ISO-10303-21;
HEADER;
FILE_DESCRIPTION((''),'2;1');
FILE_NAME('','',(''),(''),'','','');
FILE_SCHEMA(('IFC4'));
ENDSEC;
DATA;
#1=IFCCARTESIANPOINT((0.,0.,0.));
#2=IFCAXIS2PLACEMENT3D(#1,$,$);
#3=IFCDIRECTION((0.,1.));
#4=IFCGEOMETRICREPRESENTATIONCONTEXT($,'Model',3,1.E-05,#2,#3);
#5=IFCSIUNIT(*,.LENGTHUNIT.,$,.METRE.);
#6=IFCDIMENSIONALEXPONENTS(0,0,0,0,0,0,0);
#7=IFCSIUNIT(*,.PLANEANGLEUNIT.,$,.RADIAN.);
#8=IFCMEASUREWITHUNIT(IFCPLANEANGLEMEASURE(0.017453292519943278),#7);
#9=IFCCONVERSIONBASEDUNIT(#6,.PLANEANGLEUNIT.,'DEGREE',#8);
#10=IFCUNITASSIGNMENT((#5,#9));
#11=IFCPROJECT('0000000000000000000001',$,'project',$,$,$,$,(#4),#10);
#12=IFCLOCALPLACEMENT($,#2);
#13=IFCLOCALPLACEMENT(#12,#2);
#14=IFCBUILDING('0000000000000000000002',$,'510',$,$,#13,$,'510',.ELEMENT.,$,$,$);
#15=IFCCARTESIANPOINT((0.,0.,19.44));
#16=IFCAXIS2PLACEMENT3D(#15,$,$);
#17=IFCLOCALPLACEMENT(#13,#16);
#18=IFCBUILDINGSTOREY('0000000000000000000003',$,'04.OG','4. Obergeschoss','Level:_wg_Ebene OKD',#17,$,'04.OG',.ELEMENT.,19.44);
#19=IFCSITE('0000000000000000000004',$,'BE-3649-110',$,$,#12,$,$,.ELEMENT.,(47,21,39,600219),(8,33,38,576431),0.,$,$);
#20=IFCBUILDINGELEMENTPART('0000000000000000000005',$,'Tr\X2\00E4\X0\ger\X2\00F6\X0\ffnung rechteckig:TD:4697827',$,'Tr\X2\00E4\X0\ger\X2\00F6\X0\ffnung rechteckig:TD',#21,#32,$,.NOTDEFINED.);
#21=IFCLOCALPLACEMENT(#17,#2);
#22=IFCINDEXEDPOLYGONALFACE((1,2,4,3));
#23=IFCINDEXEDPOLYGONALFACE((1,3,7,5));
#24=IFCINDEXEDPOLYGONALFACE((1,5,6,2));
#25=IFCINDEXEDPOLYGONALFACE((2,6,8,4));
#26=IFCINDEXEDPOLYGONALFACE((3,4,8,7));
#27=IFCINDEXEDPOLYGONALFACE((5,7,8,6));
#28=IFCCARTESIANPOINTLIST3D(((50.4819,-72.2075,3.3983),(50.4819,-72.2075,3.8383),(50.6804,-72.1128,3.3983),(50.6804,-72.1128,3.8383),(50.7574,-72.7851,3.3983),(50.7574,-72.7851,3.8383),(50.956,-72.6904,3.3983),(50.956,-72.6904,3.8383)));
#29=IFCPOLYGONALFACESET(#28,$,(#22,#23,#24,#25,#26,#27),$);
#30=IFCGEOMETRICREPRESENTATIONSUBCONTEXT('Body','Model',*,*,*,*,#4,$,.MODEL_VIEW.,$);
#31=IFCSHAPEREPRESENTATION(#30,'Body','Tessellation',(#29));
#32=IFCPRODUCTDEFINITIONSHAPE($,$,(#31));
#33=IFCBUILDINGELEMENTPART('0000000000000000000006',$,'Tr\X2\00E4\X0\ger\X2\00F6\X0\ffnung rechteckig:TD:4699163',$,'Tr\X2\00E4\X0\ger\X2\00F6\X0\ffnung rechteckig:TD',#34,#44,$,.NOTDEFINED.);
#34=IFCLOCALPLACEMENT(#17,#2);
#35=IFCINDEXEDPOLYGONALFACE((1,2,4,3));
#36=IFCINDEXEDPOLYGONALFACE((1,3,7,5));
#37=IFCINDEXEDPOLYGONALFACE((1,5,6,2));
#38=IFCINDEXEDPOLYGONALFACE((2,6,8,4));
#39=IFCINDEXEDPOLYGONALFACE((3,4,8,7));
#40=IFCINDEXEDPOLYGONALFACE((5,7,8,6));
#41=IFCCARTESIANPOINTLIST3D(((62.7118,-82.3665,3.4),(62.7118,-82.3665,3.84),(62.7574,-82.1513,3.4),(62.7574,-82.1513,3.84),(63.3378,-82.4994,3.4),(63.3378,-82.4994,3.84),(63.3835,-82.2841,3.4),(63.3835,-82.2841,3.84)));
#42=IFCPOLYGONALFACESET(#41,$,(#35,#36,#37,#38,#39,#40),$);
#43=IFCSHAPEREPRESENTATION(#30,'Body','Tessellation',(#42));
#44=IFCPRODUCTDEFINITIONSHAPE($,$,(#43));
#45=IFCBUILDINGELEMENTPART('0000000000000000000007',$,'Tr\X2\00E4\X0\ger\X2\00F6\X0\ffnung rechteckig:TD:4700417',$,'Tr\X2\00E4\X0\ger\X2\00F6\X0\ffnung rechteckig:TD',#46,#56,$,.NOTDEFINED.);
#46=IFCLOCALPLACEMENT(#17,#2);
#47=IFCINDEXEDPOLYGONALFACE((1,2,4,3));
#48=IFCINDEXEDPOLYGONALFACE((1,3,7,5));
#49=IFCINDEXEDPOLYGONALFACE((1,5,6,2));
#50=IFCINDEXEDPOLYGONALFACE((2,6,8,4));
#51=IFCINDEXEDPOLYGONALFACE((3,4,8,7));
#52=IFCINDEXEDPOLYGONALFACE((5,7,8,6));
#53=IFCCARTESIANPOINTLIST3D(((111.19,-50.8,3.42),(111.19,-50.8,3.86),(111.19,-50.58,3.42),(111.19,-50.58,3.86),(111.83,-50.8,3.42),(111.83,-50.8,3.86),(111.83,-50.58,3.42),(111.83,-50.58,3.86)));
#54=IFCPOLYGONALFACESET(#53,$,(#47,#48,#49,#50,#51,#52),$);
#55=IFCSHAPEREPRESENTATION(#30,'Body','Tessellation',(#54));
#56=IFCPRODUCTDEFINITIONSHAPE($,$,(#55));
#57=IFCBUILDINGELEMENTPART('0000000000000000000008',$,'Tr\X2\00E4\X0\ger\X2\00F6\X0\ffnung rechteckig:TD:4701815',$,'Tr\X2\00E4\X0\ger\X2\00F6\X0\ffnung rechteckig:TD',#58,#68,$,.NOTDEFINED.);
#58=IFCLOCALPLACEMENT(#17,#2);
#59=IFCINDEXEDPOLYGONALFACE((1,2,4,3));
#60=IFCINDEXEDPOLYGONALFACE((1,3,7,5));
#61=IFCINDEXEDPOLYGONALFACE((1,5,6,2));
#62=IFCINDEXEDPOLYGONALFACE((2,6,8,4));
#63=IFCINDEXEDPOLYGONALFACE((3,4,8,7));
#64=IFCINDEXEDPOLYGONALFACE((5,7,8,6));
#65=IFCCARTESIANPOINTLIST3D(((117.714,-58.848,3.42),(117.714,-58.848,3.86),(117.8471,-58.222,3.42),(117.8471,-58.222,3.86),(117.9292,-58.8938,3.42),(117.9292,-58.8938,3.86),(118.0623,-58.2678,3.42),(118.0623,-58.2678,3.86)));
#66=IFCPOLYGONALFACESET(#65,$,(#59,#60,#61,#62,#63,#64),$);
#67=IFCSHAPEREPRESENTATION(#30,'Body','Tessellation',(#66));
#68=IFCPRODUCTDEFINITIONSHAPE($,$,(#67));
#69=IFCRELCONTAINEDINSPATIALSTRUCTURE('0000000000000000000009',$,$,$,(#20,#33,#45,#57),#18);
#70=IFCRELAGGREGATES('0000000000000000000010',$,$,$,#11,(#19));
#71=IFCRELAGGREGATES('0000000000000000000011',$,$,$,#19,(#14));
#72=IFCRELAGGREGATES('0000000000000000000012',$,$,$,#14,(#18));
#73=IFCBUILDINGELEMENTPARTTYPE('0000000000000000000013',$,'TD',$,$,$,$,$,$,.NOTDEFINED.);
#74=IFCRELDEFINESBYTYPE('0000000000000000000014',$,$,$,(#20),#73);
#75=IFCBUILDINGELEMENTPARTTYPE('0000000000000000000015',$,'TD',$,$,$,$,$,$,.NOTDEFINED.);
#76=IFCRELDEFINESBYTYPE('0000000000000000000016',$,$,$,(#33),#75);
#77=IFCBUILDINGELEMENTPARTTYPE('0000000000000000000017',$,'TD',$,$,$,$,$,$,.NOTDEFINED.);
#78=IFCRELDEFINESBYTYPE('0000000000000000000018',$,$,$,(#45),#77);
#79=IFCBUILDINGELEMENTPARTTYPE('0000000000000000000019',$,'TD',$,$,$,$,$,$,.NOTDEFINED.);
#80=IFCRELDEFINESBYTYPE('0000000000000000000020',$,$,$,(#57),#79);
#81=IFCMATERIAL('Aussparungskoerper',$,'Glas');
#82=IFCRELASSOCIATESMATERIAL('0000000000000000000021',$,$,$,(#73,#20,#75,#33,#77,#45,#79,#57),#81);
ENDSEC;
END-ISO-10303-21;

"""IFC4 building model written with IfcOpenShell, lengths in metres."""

from ifc_helpers import new_model, entity, si_unit, converted_unit, direction, frame, origin, place, context, subcontext, project, spatial, indexed_curve, outline, extrude, source, transform, mapped, material, type_object, type_shapes, element, save


model = new_model("IFC4")

# Units and contexts
model_context = context("Model", 3, precision=1e-05, world=origin(), true_north=direction((0.0, 1.0)))
body_context = subcontext(model_context, "Body", "Model", "MODEL_VIEW")
ifc_project = project(units=[si_unit("LENGTHUNIT", "METRE"), converted_unit("PLANEANGLEUNIT", "DEGREE", entity("IfcPlaneAngleMeasure", 0.017453292519943278), si_unit("PLANEANGLEUNIT", "RADIAN"), dimensions=[0, 0, 0, 0, 0, 0, 0])], contexts=[model_context])

# Site, building, storey
site_placement = place(None, origin())
site = spatial("IfcSite", under=ifc_project, at=site_placement, Name="BE-3649-110", CompositionType="ELEMENT", RefLatitude=(47, 21, 39, 600219), RefLongitude=(8, 33, 38, 576431), RefElevation=0.0)
building_placement = place(site_placement, origin())
building = spatial("IfcBuilding", under=site, at=building_placement, Name="510", LongName="510", CompositionType="ELEMENT")
storey_placement = place(building_placement, frame((0.0, 0.0, 19.44)))
storey = spatial("IfcBuildingStorey", under=building, at=storey_placement, Name="04.OG", Description="4. Obergeschoss", ObjectType="Level:_wg_Ebene OKD", LongName="04.OG", CompositionType="ELEMENT", Elevation=19.44)

# Building element parts
ifc_material_1 = material(Name="Aussparungskoerper", Category="Glas")
building_element_part_type_1 = type_object("IfcBuildingElementPartType", Name="TD", PredefinedType="NOTDEFINED", material=ifc_material_1)
shared_shape_1 = source(origin(), body_context, "Body", "SweptSolid", [
    extrude(outline(indexed_curve([(-0.11, -0.32), (0.11, -0.32), (0.11, 0.32), (-0.11, 0.32), (-0.11, -0.32)], self_intersect=False)), frame((50.7189, -72.449, -0.44), z_axis=(0.0, 0.0, 1.0), x_axis=(0.902586, 0.43051, 0.0)), (0.0, 0.0, 1.0), 0.44),
])
type_shapes(building_element_part_type_1, [shared_shape_1])
building_element_part_1_placement = place(storey_placement, frame((0.0, 0.0, 3.8383)))
element("IfcBuildingElementPart", 1, at=building_element_part_1_placement, inside=storey, type_object=building_element_part_type_1, material=ifc_material_1, Name="Trägeröffnung rechteckig:TD:4697827", ObjectType="Trägeröffnung rechteckig:TD", PredefinedType="NOTDEFINED", context=body_context, shape_type="MappedRepresentation", body=[
    mapped(shared_shape_1, transform((0.0, 0.0, 0.0), scale=1.0)),
])
building_element_part_type_2 = type_object("IfcBuildingElementPartType", Name="TD", PredefinedType="NOTDEFINED", material=ifc_material_1)
shared_shape_2 = source(origin(), body_context, "Body", "SweptSolid", [
    extrude(outline(indexed_curve([(-0.22, -0.32), (0.22, -0.32), (0.22, 0.32), (-0.22, 0.32), (-0.22, -0.32)], self_intersect=False)), frame((0.0, 0.0, -0.22), z_axis=(0.0, 0.0, 1.0), x_axis=(0.0, 1.0, 0.0)), (0.0, 0.0, 1.0), 0.22),
])
type_shapes(building_element_part_type_2, [shared_shape_2])
building_element_part_2_placement = place(storey_placement, frame((63.0248, -82.4329, 3.62), z_axis=(-0.207566, -0.978221, 0.0), x_axis=(0.978221, -0.207566, 0.0)))
element("IfcBuildingElementPart", 2, at=building_element_part_2_placement, inside=storey, type_object=building_element_part_type_2, material=ifc_material_1, Name="Trägeröffnung rechteckig:TD:4699163", ObjectType="Trägeröffnung rechteckig:TD", PredefinedType="NOTDEFINED", context=body_context, shape_type="MappedRepresentation", body=[
    mapped(shared_shape_2, transform((0.0, 0.0, 0.0), scale=1.0)),
])
building_element_part_type_3 = type_object("IfcBuildingElementPartType", Name="TD", PredefinedType="NOTDEFINED", material=ifc_material_1)
shared_shape_3 = source(origin(), body_context, "Body", "SweptSolid", [
    extrude(outline(indexed_curve([(-0.11, -0.32), (0.11, -0.32), (0.11, 0.32), (-0.11, 0.32), (-0.11, -0.32)], self_intersect=False)), frame((111.51, -50.69, -0.44), z_axis=(0.0, 0.0, 1.0), x_axis=(0.0, 1.0, 0.0)), (0.0, 0.0, 1.0), 0.44),
])
type_shapes(building_element_part_type_3, [shared_shape_3])
building_element_part_3_placement = place(storey_placement, frame((0.0, 0.0, 3.86)))
element("IfcBuildingElementPart", 3, at=building_element_part_3_placement, inside=storey, type_object=building_element_part_type_3, material=ifc_material_1, Name="Trägeröffnung rechteckig:TD:4700417", ObjectType="Trägeröffnung rechteckig:TD", PredefinedType="NOTDEFINED", context=body_context, shape_type="MappedRepresentation", body=[
    mapped(shared_shape_3, transform((0.0, 0.0, 0.0), scale=1.0)),
])
building_element_part_type_4 = type_object("IfcBuildingElementPartType", Name="TD", PredefinedType="NOTDEFINED", material=ifc_material_1)
shared_shape_4 = source(origin(), body_context, "Body", "SweptSolid", [
    extrude(outline(indexed_curve([(-0.32, -0.11), (0.32, -0.11), (0.32, 0.11), (-0.32, 0.11), (-0.32, -0.11)], self_intersect=False)), frame((117.8881, -58.5579, -0.44), z_axis=(0.0, 0.0, 1.0), x_axis=(-0.207912, -0.978148, 0.0)), (0.0, 0.0, 1.0), 0.44),
])
type_shapes(building_element_part_type_4, [shared_shape_4])
building_element_part_4_placement = place(storey_placement, frame((0.0, 0.0, 3.86)))
element("IfcBuildingElementPart", 4, at=building_element_part_4_placement, inside=storey, type_object=building_element_part_type_4, material=ifc_material_1, Name="Trägeröffnung rechteckig:TD:4701815", ObjectType="Trägeröffnung rechteckig:TD", PredefinedType="NOTDEFINED", context=body_context, shape_type="MappedRepresentation", body=[
    mapped(shared_shape_4, transform((0.0, 0.0, 0.0), scale=1.0)),
])

save(model, "model.ifc")
